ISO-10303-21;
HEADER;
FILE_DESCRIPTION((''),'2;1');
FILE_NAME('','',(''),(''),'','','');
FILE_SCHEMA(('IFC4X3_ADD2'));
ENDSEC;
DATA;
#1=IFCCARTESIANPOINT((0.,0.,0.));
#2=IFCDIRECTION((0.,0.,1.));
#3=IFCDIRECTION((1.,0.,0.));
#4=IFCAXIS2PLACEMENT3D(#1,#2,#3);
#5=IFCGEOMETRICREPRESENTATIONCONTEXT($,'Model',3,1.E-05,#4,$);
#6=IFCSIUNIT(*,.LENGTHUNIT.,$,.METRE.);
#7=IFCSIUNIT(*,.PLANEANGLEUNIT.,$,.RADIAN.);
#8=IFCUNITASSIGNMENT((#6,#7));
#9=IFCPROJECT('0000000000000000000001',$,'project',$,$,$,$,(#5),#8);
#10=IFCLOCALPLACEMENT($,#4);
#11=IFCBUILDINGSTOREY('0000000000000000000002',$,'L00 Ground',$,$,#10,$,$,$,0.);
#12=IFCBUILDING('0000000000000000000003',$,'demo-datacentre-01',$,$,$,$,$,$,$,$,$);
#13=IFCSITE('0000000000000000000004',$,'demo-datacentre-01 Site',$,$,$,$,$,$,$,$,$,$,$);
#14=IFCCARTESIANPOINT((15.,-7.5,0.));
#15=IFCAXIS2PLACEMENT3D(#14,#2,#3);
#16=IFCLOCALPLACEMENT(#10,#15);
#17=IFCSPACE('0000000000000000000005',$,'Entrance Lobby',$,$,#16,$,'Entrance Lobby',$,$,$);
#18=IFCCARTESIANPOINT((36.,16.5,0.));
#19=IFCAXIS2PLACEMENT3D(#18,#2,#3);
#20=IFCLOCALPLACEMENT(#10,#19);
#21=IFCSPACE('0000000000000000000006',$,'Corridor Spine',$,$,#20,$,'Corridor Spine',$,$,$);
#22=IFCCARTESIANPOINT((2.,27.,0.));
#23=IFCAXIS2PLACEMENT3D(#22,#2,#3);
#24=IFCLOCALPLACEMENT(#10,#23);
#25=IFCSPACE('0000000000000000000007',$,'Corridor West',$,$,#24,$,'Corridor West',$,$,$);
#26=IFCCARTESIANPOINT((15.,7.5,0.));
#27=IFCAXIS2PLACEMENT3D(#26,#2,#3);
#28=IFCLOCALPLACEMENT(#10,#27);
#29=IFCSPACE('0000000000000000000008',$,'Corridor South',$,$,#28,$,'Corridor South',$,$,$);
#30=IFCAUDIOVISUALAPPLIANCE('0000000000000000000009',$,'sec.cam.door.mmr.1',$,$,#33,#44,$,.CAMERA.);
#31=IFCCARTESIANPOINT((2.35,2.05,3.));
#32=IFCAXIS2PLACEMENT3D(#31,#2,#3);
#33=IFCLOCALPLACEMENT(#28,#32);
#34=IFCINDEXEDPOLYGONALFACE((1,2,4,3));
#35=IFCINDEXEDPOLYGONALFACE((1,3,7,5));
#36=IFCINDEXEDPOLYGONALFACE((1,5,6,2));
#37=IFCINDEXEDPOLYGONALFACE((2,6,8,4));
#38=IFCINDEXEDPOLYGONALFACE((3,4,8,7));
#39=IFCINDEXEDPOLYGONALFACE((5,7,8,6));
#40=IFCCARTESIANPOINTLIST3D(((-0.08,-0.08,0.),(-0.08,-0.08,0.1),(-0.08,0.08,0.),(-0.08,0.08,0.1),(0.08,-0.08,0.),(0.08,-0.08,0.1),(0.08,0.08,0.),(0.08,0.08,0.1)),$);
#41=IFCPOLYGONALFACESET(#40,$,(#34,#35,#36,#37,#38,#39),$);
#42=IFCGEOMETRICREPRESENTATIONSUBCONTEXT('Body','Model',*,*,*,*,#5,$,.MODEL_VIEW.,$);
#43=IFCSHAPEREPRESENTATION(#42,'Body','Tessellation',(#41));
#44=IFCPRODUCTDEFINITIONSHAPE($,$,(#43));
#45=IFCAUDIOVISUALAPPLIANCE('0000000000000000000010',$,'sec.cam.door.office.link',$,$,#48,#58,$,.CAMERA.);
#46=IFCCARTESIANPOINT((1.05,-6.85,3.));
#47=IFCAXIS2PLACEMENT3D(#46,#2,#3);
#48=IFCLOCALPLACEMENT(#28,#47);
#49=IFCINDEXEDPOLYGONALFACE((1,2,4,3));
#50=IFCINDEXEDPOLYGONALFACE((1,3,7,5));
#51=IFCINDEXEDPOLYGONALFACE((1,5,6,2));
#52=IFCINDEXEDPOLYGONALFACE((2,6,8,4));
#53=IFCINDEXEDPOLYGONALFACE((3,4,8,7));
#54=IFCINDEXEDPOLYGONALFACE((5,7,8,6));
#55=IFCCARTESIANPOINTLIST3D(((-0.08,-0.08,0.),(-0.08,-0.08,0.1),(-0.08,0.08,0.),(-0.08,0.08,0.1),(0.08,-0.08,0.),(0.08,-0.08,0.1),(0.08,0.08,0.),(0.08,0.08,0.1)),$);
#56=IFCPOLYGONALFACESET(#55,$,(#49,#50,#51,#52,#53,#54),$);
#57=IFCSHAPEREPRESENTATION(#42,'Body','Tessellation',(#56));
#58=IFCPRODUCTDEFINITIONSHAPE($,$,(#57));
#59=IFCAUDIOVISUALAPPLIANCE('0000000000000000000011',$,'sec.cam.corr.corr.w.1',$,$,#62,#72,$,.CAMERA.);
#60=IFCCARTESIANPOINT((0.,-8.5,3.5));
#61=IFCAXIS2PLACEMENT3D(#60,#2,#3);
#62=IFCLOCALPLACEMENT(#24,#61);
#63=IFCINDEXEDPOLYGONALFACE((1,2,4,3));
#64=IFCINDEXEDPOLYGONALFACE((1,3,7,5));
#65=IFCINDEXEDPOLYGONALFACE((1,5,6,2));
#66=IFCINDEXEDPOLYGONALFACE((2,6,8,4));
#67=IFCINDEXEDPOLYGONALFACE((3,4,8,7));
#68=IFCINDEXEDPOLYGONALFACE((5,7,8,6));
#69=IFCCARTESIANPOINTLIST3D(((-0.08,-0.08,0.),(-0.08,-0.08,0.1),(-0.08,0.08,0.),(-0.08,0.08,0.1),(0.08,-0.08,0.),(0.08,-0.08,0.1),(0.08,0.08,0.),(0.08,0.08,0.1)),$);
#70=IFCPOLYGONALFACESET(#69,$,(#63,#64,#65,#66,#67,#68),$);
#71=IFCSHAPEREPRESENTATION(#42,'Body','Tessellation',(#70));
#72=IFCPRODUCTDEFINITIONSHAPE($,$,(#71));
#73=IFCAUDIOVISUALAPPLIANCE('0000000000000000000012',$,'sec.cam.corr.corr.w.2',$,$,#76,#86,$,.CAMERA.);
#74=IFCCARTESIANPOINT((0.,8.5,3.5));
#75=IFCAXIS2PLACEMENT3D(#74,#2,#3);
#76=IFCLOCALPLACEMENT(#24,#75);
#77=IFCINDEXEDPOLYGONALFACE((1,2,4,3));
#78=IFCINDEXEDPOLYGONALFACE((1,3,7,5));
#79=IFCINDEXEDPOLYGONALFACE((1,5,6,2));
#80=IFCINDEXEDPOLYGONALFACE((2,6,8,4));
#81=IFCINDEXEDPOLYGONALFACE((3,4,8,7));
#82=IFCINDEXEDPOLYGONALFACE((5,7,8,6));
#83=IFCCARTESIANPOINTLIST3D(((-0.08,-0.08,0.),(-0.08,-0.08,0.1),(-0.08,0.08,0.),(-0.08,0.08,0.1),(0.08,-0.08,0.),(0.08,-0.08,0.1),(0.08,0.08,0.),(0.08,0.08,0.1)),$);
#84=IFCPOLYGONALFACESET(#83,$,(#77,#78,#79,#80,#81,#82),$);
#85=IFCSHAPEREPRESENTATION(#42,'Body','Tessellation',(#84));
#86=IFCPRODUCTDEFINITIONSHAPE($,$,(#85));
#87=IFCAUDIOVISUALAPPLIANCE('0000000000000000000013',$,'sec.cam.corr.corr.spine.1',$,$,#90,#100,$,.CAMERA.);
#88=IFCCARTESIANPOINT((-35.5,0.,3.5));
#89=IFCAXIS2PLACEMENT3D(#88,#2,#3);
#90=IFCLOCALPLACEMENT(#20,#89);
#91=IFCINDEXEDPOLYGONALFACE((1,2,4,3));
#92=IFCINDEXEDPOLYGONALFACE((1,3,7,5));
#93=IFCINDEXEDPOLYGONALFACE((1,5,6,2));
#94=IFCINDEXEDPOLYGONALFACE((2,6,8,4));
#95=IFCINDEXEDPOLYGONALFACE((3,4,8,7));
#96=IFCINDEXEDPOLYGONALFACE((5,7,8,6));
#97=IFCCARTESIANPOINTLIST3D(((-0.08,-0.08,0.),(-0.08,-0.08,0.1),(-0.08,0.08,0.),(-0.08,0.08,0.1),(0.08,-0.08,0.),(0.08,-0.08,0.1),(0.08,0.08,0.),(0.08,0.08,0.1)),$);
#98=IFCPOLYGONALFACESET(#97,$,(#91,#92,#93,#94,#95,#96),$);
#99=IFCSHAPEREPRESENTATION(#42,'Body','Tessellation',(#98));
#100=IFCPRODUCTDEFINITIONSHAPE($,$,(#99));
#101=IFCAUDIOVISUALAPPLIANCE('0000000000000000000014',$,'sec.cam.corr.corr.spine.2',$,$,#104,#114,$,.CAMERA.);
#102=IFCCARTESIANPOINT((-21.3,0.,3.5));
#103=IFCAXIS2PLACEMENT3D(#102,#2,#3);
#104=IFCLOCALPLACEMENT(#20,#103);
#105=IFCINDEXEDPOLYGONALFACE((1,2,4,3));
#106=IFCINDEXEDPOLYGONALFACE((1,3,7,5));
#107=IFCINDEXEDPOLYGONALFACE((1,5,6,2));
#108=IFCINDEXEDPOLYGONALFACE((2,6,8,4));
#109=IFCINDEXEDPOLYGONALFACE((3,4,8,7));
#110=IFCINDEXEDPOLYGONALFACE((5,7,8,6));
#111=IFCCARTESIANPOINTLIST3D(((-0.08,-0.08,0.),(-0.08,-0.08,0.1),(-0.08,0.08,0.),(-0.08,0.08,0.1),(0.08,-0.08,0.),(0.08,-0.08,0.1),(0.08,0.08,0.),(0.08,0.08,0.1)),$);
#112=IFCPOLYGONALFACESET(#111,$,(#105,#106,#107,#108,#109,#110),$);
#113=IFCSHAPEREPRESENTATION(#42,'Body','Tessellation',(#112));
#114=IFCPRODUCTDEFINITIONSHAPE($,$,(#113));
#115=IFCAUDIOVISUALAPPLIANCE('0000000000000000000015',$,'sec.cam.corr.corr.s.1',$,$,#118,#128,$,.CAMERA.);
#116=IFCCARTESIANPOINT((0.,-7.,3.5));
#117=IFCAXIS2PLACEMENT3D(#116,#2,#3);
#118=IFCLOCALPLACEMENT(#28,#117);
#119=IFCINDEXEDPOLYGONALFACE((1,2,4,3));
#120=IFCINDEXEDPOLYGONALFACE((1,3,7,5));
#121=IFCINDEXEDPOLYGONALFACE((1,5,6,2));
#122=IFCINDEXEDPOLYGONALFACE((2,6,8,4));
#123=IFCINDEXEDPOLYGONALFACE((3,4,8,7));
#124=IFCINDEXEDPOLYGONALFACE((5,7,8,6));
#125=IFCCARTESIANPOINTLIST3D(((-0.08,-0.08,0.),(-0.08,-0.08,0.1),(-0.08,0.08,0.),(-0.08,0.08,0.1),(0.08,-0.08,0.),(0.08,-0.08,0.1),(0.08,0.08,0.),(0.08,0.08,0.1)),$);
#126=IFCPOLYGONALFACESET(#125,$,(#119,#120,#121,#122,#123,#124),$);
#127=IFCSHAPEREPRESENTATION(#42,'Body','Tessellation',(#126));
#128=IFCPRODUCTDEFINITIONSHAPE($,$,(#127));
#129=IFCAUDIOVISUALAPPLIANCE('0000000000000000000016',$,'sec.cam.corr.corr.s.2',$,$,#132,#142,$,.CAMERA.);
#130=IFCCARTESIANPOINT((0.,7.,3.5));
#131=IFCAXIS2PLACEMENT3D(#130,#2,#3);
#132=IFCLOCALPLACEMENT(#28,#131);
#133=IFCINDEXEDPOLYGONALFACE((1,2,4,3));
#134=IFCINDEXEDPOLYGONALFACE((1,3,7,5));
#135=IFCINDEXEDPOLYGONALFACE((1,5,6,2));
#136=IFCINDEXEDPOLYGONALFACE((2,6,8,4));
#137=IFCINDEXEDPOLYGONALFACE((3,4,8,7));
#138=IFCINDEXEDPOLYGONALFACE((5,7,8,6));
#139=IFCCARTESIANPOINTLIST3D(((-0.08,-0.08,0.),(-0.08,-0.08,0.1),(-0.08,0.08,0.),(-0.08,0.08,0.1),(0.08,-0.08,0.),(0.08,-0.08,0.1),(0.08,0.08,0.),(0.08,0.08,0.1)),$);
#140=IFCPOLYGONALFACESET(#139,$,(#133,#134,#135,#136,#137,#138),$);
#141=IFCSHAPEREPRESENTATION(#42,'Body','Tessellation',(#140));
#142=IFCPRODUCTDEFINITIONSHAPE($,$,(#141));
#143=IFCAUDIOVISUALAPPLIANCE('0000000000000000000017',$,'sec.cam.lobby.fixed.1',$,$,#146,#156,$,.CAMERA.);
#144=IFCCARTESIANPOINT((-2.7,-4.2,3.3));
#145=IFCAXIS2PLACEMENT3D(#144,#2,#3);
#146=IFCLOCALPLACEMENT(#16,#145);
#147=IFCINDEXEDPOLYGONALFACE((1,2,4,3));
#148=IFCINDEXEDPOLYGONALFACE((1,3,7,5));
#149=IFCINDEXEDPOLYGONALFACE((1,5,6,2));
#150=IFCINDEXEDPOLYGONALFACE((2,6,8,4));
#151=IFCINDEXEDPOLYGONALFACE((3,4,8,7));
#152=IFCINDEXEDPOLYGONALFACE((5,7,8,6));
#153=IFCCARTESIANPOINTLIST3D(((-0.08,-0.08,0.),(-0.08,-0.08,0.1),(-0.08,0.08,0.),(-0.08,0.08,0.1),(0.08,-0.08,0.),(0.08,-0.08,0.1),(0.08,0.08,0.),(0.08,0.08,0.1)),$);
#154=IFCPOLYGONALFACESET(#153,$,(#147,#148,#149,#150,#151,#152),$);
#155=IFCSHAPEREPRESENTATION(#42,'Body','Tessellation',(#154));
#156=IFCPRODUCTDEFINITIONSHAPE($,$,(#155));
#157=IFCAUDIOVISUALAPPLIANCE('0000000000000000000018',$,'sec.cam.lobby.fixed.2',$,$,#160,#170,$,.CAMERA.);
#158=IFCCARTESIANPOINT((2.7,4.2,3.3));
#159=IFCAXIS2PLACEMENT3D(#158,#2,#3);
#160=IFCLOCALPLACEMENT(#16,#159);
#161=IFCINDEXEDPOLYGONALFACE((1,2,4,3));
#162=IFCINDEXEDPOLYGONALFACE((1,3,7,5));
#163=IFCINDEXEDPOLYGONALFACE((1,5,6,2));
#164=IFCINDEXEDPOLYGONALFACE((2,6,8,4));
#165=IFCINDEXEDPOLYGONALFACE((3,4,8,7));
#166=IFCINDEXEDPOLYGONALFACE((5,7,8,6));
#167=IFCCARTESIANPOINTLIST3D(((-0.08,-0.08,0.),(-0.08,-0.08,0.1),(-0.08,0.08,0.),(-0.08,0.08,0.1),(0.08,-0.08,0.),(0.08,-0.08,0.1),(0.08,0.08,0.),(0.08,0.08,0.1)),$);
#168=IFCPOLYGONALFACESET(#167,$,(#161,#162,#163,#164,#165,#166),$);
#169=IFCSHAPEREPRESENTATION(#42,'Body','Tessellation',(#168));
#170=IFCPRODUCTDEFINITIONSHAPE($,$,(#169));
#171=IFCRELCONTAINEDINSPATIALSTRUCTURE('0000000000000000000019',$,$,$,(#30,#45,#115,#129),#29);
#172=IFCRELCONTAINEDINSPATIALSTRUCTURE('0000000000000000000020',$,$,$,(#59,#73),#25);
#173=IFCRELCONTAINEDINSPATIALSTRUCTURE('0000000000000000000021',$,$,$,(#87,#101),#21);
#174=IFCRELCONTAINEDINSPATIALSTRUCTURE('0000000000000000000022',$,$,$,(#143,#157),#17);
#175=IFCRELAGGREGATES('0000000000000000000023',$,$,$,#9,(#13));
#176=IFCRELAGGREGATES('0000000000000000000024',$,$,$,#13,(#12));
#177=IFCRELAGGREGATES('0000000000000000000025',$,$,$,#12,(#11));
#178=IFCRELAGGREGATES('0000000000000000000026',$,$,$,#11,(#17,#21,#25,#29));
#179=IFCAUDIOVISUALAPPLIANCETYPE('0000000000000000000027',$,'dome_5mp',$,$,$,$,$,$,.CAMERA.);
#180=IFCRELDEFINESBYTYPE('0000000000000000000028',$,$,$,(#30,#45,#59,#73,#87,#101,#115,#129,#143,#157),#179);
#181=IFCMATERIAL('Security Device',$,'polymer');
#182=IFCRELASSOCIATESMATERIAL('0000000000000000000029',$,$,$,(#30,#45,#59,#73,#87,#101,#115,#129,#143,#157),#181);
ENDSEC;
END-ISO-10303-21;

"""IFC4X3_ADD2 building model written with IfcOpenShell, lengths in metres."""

from ifc_helpers import new_model, si_unit, frame, origin_with_axes, place, context, subcontext, project, spatial, rectangle, extrude, source, transform, mapped, material, type_object, type_shapes, element, save


model = new_model("IFC4X3_ADD2")

# Units and contexts
model_context = context("Model", 3, precision=1e-05, world=origin_with_axes())
body_context = subcontext(model_context, "Body", "Model", "MODEL_VIEW")
ifc_project = project(units=[si_unit("LENGTHUNIT", "METRE"), si_unit("PLANEANGLEUNIT", "RADIAN")], contexts=[model_context])

# Site, building, storey
site = spatial("IfcSite", under=ifc_project, Name="demo-datacentre-01 Site")
building = spatial("IfcBuilding", under=site, Name="demo-datacentre-01")
storey_placement = place(None, origin_with_axes())
storey = spatial("IfcBuildingStorey", under=building, at=storey_placement, Name="L00 Ground", Elevation=0.0)

# Shared definitions
ifc_material = material(Name="Security Device", Category="polymer")

# Shared definitions
space_1_placement = place(storey_placement, frame((15.0, -7.5, 0.0), z_axis=(0.0, 0.0, 1.0), x_axis=(1.0, 0.0, 0.0)))
space_1 = spatial("IfcSpace", under=storey, at=space_1_placement, Name="Entrance Lobby", LongName="Entrance Lobby")

# Shared definitions
space_2_placement = place(storey_placement, frame((36.0, 16.5, 0.0), z_axis=(0.0, 0.0, 1.0), x_axis=(1.0, 0.0, 0.0)))
space_2 = spatial("IfcSpace", under=storey, at=space_2_placement, Name="Corridor Spine", LongName="Corridor Spine")

# Shared definitions
space_3_placement = place(storey_placement, frame((2.0, 27.0, 0.0), z_axis=(0.0, 0.0, 1.0), x_axis=(1.0, 0.0, 0.0)))
space_3 = spatial("IfcSpace", under=storey, at=space_3_placement, Name="Corridor West", LongName="Corridor West")

# Shared definitions
space_4_placement = place(storey_placement, frame((15.0, 7.5, 0.0), z_axis=(0.0, 0.0, 1.0), x_axis=(1.0, 0.0, 0.0)))
space_4 = spatial("IfcSpace", under=storey, at=space_4_placement, Name="Corridor South", LongName="Corridor South")

# Audio visual appliances
audio_visual_appliance_type_1 = type_object("IfcAudioVisualApplianceType", Name="dome_5mp", PredefinedType="CAMERA")
shared_shape_1 = source(origin_with_axes(), body_context, "Body", "SweptSolid", [
    extrude(rectangle(XDim=0.16, YDim=0.16), origin_with_axes(), (0.0, 0.0, 1.0), 0.1),
])
type_shapes(audio_visual_appliance_type_1, [shared_shape_1])
for number, where, z_axis, x_axis, name in (
    (1, (2.35, 2.05, 3.0), (0.0, 0.0, 1.0), (1.0, 0.0, 0.0), "sec.cam.door.mmr.1"),
    (2, (1.05, -6.85, 3.0), (0.0, 0.0, 1.0), (1.0, 0.0, 0.0), "sec.cam.door.office.link"),
):
    element("IfcAudioVisualAppliance", number, at=place(space_4_placement, frame(where, z_axis=z_axis, x_axis=x_axis)), inside=space_4, type_object=audio_visual_appliance_type_1, material=ifc_material, Name=name, PredefinedType="CAMERA", context=body_context, shape_type="MappedRepresentation", body=[
        mapped(shared_shape_1, transform((0.0, 0.0, 0.0), x_axis=(1.0, 0.0, 0.0), y_axis=(0.0, 1.0, 0.0), z_axis=(0.0, 0.0, 1.0), scale=1.0)),
    ])
for number, where, z_axis, x_axis, name in (
    (3, (0.0, -8.5, 3.5), (0.0, 0.0, 1.0), (1.0, 0.0, 0.0), "sec.cam.corr.corr.w.1"),
    (4, (0.0, 8.5, 3.5), (0.0, 0.0, 1.0), (1.0, 0.0, 0.0), "sec.cam.corr.corr.w.2"),
):
    element("IfcAudioVisualAppliance", number, at=place(space_3_placement, frame(where, z_axis=z_axis, x_axis=x_axis)), inside=space_3, type_object=audio_visual_appliance_type_1, material=ifc_material, Name=name, PredefinedType="CAMERA", context=body_context, shape_type="MappedRepresentation", body=[
        mapped(shared_shape_1, transform((0.0, 0.0, 0.0), x_axis=(1.0, 0.0, 0.0), y_axis=(0.0, 1.0, 0.0), z_axis=(0.0, 0.0, 1.0), scale=1.0)),
    ])
for number, where, z_axis, x_axis, name in (
    (5, (-35.5, 0.0, 3.5), (0.0, 0.0, 1.0), (1.0, 0.0, 0.0), "sec.cam.corr.corr.spine.1"),
    (6, (-21.3, 0.0, 3.5), (0.0, 0.0, 1.0), (1.0, 0.0, 0.0), "sec.cam.corr.corr.spine.2"),
):
    element("IfcAudioVisualAppliance", number, at=place(space_2_placement, frame(where, z_axis=z_axis, x_axis=x_axis)), inside=space_2, type_object=audio_visual_appliance_type_1, material=ifc_material, Name=name, PredefinedType="CAMERA", context=body_context, shape_type="MappedRepresentation", body=[
        mapped(shared_shape_1, transform((0.0, 0.0, 0.0), x_axis=(1.0, 0.0, 0.0), y_axis=(0.0, 1.0, 0.0), z_axis=(0.0, 0.0, 1.0), scale=1.0)),
    ])
for number, where, z_axis, x_axis, name in (
    (7, (0.0, -7.0, 3.5), (0.0, 0.0, 1.0), (1.0, 0.0, 0.0), "sec.cam.corr.corr.s.1"),
    (8, (0.0, 7.0, 3.5), (0.0, 0.0, 1.0), (1.0, 0.0, 0.0), "sec.cam.corr.corr.s.2"),
):
    element("IfcAudioVisualAppliance", number, at=place(space_4_placement, frame(where, z_axis=z_axis, x_axis=x_axis)), inside=space_4, type_object=audio_visual_appliance_type_1, material=ifc_material, Name=name, PredefinedType="CAMERA", context=body_context, shape_type="MappedRepresentation", body=[
        mapped(shared_shape_1, transform((0.0, 0.0, 0.0), x_axis=(1.0, 0.0, 0.0), y_axis=(0.0, 1.0, 0.0), z_axis=(0.0, 0.0, 1.0), scale=1.0)),
    ])

# Audio visual appliances
for number, where, z_axis, x_axis, name in (
    (9, (-2.7, -4.2, 3.3), (0.0, 0.0, 1.0), (1.0, 0.0, 0.0), "sec.cam.lobby.fixed.1"),
    (10, (2.7, 4.2, 3.3), (0.0, 0.0, 1.0), (1.0, 0.0, 0.0), "sec.cam.lobby.fixed.2"),
):
    element("IfcAudioVisualAppliance", number, at=place(space_1_placement, frame(where, z_axis=z_axis, x_axis=x_axis)), inside=space_1, type_object=audio_visual_appliance_type_1, material=ifc_material, Name=name, PredefinedType="CAMERA", context=body_context, shape_type="MappedRepresentation", body=[
        mapped(shared_shape_1, transform((0.0, 0.0, 0.0), x_axis=(1.0, 0.0, 0.0), y_axis=(0.0, 1.0, 0.0), z_axis=(0.0, 0.0, 1.0), scale=1.0)),
    ])

save(model, "model.ifc")
